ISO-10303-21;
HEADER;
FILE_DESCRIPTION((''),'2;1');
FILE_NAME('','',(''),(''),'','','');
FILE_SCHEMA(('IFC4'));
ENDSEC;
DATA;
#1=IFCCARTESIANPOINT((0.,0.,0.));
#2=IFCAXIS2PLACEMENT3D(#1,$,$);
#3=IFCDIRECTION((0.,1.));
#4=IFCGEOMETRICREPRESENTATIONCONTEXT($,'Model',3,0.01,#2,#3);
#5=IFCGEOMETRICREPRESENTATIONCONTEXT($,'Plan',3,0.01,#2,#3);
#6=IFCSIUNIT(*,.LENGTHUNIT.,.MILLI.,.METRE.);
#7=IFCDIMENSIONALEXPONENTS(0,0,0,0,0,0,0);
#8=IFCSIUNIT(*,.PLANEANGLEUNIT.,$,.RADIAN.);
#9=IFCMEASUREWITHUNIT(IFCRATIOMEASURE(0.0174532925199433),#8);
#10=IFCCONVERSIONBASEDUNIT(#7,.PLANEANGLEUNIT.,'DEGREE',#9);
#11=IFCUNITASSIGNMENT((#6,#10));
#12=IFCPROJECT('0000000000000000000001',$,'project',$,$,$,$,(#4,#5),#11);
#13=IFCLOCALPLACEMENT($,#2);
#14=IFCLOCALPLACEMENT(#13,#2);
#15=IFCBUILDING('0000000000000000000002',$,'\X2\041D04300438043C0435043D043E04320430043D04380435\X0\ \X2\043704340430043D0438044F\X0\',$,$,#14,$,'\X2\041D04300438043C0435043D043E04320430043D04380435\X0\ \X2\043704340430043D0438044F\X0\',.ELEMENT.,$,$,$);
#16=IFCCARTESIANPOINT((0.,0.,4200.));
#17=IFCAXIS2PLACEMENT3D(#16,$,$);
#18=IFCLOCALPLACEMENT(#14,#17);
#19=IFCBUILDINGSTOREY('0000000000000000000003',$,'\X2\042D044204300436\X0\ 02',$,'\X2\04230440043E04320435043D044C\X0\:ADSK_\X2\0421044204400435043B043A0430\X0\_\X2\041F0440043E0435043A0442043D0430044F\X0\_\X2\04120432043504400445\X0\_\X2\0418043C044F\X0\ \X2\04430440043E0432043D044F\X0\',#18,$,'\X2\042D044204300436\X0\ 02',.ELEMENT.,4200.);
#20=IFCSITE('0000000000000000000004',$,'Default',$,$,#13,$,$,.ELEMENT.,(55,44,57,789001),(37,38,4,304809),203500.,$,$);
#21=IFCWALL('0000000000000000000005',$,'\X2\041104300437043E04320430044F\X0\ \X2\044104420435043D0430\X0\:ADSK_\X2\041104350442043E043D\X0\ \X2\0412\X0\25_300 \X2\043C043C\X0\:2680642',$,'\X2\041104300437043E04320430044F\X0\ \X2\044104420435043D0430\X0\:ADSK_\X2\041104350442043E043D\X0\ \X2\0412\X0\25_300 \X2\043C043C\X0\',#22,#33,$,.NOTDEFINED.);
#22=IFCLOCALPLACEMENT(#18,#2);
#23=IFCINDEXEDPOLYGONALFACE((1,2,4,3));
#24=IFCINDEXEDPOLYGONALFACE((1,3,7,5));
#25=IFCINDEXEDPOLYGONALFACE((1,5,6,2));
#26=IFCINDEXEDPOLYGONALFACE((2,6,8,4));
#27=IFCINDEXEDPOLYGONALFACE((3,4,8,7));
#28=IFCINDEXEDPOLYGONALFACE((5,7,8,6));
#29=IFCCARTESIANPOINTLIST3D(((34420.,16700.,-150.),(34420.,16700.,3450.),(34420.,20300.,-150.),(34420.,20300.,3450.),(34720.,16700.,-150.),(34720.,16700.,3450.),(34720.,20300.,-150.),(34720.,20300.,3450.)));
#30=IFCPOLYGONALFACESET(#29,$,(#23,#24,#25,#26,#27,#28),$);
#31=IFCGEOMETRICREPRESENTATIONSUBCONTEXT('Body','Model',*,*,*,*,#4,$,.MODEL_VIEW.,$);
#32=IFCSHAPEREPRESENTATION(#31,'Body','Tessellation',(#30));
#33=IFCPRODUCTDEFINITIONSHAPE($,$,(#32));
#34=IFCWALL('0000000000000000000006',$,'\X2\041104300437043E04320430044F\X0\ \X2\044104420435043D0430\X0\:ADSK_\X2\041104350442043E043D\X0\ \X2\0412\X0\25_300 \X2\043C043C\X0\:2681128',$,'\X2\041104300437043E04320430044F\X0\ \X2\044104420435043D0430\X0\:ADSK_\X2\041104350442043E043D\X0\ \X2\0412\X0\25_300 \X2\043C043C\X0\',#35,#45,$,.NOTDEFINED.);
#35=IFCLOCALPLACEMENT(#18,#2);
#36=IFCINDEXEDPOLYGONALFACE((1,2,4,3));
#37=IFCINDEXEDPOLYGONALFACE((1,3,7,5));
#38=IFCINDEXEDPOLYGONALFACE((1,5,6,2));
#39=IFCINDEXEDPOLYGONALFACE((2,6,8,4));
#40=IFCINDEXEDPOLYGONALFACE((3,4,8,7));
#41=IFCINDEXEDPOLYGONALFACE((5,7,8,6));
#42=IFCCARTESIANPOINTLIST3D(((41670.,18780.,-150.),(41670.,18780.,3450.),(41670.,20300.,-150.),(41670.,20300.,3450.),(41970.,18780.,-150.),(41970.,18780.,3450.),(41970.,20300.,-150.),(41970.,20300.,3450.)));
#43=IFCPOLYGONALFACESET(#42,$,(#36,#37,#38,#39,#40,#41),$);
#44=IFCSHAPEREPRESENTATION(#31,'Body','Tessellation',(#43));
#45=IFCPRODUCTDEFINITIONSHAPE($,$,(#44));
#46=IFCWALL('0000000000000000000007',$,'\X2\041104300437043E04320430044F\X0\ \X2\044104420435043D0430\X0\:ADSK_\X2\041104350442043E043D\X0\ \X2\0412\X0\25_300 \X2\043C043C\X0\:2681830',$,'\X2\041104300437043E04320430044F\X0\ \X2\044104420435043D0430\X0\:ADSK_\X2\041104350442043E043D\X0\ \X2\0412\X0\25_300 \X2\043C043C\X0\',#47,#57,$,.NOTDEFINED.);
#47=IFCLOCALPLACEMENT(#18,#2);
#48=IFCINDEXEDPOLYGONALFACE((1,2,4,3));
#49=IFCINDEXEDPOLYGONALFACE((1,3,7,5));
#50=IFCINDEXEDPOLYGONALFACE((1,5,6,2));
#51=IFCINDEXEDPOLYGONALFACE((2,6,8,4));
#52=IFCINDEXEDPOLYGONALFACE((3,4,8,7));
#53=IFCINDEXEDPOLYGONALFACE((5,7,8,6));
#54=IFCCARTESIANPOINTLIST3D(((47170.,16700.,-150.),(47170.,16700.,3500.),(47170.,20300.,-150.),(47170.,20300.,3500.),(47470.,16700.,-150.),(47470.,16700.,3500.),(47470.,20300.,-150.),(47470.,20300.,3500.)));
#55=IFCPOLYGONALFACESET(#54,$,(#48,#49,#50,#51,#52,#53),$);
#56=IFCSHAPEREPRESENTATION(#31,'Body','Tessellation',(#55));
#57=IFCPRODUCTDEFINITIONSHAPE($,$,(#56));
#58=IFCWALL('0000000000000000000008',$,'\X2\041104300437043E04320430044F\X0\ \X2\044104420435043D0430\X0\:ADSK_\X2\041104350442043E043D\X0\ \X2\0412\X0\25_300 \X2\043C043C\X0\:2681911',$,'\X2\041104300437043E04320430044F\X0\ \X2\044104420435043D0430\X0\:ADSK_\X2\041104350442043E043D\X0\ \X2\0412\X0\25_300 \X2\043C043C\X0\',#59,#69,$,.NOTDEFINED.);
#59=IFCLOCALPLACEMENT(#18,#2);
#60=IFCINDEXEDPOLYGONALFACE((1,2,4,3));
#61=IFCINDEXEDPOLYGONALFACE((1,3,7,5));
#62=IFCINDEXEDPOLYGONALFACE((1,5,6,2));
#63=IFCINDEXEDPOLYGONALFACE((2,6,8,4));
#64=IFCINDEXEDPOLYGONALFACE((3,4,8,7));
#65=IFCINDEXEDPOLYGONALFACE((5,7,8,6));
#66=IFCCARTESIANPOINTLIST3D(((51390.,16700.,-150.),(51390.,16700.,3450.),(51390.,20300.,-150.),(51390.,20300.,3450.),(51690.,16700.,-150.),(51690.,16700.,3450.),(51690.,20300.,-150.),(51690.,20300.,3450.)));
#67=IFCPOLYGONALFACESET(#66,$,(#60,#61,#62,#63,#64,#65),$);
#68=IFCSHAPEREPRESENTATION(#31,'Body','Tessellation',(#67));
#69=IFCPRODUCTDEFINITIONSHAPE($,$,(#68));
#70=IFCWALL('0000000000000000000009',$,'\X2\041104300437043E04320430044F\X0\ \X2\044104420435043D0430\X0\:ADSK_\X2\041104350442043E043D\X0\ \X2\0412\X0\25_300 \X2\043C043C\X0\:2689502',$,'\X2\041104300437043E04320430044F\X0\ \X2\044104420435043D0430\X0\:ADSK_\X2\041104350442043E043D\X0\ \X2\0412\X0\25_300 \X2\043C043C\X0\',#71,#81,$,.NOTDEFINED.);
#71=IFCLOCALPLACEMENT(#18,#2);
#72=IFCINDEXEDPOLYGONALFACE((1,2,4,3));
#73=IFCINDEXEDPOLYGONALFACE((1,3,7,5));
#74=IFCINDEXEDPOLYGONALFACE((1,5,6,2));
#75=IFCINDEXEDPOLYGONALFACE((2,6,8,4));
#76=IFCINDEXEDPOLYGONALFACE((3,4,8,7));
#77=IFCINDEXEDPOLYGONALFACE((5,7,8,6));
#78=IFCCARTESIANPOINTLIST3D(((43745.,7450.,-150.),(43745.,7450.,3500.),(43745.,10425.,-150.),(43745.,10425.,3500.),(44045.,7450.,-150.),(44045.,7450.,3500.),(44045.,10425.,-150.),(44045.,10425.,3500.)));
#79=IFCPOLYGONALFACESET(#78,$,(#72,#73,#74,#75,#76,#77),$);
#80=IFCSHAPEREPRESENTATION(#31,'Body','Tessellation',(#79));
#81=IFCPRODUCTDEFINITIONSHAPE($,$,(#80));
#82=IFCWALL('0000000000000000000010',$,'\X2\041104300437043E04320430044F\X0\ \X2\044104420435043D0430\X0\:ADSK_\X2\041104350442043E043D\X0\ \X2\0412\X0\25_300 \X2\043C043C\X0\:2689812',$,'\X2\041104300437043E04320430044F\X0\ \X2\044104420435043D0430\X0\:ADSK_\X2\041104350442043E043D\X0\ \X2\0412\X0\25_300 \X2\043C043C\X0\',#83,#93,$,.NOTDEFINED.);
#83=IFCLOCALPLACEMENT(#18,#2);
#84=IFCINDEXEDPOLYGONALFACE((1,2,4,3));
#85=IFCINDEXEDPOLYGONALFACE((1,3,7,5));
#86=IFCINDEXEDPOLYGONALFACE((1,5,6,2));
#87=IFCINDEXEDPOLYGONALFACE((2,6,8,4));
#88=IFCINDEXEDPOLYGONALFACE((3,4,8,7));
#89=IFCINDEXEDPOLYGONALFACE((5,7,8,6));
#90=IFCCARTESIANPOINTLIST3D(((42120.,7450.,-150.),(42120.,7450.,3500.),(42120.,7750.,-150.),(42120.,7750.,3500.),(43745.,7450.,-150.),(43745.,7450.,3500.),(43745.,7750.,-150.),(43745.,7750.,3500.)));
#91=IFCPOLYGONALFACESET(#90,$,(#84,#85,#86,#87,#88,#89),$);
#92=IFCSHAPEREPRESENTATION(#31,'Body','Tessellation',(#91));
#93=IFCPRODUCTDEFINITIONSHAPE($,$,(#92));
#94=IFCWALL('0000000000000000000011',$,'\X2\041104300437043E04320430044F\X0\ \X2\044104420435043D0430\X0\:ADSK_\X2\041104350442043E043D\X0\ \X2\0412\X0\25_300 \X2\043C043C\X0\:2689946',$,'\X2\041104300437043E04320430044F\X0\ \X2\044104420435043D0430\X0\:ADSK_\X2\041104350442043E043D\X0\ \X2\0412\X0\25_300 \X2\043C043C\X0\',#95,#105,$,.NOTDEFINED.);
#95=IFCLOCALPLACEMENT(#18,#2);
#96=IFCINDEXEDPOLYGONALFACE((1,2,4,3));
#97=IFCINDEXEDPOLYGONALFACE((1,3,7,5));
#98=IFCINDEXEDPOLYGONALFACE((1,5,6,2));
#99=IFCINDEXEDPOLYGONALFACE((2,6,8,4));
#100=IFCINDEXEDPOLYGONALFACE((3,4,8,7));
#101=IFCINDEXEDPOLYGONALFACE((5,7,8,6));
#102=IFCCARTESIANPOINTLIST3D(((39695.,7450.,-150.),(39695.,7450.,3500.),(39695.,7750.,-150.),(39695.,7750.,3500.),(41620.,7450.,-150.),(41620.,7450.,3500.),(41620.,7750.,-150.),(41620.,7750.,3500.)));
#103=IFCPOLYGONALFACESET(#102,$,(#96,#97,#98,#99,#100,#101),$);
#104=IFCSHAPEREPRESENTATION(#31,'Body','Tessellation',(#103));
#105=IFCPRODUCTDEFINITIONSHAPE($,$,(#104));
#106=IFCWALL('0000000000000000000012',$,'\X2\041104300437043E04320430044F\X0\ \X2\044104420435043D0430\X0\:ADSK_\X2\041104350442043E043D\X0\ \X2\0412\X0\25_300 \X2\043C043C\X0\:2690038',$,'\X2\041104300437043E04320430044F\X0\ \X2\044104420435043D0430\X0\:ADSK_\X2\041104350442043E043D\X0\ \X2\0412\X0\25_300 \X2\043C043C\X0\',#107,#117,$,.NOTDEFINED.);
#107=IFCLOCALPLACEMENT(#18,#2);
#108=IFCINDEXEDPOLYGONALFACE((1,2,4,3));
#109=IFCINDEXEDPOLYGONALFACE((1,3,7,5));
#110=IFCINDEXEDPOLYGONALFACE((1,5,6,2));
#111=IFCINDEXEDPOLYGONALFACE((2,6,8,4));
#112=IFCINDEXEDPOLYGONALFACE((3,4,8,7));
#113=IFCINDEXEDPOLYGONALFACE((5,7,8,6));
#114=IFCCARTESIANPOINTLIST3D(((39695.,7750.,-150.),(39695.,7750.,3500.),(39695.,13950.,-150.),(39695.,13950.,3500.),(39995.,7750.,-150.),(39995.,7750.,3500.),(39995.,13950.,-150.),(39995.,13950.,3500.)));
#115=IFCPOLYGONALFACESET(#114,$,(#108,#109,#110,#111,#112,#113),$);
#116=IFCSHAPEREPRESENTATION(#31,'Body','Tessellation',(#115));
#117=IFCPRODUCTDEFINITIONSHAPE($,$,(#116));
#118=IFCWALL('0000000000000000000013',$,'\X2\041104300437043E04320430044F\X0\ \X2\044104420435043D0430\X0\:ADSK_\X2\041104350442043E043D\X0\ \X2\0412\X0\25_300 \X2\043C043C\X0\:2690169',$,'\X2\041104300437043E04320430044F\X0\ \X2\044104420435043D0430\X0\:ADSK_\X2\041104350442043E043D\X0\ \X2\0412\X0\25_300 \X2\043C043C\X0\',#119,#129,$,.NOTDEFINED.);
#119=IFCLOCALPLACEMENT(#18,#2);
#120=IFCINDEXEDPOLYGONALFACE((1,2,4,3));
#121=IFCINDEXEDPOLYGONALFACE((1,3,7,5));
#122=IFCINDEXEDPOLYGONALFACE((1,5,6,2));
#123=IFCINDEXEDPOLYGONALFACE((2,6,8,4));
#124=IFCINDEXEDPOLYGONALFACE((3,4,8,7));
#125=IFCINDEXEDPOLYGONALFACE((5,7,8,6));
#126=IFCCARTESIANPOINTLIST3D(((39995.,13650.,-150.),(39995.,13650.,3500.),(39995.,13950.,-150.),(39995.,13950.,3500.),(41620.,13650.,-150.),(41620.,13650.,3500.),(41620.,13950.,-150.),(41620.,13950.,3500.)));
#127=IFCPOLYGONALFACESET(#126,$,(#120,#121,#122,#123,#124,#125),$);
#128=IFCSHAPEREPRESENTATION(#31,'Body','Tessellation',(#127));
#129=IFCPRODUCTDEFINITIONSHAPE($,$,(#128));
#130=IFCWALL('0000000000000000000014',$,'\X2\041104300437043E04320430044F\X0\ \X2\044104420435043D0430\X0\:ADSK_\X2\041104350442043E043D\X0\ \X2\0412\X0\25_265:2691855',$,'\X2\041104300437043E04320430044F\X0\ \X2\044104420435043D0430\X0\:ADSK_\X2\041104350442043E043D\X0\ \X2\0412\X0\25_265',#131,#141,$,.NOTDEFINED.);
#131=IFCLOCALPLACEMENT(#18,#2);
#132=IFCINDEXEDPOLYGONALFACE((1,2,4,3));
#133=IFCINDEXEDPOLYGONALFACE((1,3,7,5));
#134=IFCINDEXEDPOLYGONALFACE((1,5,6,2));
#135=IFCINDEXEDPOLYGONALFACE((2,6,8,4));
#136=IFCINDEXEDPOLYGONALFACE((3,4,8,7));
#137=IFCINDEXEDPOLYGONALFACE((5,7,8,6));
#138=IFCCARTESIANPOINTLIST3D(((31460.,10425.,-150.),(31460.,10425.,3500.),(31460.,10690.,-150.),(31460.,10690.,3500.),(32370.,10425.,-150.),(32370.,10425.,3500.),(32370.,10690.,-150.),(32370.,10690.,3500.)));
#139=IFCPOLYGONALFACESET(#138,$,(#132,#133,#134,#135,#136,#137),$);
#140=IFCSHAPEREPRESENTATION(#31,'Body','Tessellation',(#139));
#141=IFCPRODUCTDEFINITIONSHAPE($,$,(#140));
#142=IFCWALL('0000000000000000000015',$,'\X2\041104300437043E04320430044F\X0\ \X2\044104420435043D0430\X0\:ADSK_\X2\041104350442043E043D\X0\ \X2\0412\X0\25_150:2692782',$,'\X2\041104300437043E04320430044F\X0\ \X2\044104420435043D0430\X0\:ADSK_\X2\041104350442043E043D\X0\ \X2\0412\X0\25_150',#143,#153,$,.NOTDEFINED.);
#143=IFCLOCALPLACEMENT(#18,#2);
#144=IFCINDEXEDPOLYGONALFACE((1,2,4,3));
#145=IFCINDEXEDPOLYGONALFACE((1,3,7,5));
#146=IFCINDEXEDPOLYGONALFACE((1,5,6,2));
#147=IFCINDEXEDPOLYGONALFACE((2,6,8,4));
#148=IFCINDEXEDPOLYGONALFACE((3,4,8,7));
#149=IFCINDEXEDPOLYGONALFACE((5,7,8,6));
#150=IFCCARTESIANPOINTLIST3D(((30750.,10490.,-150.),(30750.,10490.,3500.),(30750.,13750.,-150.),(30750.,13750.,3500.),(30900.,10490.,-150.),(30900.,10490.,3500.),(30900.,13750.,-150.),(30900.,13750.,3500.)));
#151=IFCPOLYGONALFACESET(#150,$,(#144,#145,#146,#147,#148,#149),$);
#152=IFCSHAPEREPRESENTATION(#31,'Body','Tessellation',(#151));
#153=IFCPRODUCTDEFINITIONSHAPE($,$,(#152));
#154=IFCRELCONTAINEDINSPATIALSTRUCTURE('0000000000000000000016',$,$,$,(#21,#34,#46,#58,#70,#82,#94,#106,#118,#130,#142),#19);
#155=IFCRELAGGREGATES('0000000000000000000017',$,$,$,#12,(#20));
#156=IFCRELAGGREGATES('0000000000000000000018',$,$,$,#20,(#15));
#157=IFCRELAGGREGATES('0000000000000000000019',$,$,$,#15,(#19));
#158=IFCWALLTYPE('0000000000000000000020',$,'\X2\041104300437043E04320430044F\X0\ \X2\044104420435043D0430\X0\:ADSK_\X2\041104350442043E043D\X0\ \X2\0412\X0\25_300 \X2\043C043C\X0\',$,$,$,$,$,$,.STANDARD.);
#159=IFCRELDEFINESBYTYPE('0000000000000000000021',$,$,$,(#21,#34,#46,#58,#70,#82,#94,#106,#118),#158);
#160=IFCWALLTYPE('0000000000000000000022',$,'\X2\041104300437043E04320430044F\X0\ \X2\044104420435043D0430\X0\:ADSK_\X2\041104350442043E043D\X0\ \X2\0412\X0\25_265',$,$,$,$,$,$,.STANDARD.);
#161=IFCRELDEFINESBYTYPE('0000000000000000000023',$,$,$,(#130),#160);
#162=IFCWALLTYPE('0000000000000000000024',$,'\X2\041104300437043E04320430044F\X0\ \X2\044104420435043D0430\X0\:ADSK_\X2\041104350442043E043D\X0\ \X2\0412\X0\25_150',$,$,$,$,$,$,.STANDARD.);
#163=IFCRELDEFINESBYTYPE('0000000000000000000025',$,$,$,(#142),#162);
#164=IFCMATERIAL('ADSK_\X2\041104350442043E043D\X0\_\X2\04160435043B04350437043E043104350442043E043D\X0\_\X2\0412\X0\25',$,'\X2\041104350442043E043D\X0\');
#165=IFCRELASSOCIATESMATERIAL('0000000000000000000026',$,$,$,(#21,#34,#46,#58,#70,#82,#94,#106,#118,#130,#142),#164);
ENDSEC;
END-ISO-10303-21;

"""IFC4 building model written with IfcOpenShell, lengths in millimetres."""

from ifc_helpers import new_model, entity, si_unit, converted_unit, direction, frame, origin, place, context, subcontext, project, spatial, indexed_curve, outline, extrude, material, type_object, element, save


model = new_model("IFC4")

# Units and contexts
model_context = context("Model", 3, precision=0.01, world=origin(), true_north=direction((0.0, 1.0)))
plan_context = context("Plan", 3, precision=0.01, world=origin(), true_north=direction((0.0, 1.0)))
body_context = subcontext(model_context, "Body", "Model", "MODEL_VIEW")
ifc_project = project(units=[si_unit("LENGTHUNIT", "METRE", prefix="MILLI"), converted_unit("PLANEANGLEUNIT", "DEGREE", entity("IfcRatioMeasure", 0.0174532925199433), si_unit("PLANEANGLEUNIT", "RADIAN"), dimensions=[0, 0, 0, 0, 0, 0, 0])], contexts=[model_context, plan_context])

# Site, building, storey
site_placement = place(None, origin())
site = spatial("IfcSite", under=ifc_project, at=site_placement, Name="Default", CompositionType="ELEMENT", RefLatitude=(55, 44, 57, 789001), RefLongitude=(37, 38, 4, 304809), RefElevation=203500.0)
building_placement = place(site_placement, origin())
building = spatial("IfcBuilding", under=site, at=building_placement, Name="Наименование здания", LongName="Наименование здания", CompositionType="ELEMENT")
storey_placement = place(building_placement, frame((0.0, 0.0, 4200.0)))
storey = spatial("IfcBuildingStorey", under=building, at=storey_placement, Name="Этаж 02", ObjectType="Уровень:ADSK_Стрелка_Проектная_Вверх_Имя уровня", LongName="Этаж 02", CompositionType="ELEMENT", Elevation=4200.0)

# Walls
ifc_material = material(Name="ADSK_Бетон_Железобетон_В25", Category="Бетон")
wall_type_1 = type_object("IfcWallType", Name="Базовая стена:ADSK_Бетон В25_300 мм", PredefinedType="STANDARD")
wall_1_placement = place(storey_placement, frame((34570.0, 20300.0, -150.0), z_axis=(0.0, 0.0, 1.0), x_axis=(0.0, -1.0, 0.0)))
element("IfcWall", 1, at=wall_1_placement, inside=storey, type_object=wall_type_1, material=ifc_material, Name="Базовая стена:ADSK_Бетон В25_300 мм:2680642", ObjectType="Базовая стена:ADSK_Бетон В25_300 мм", PredefinedType="NOTDEFINED", context=body_context, shape_type="SweptSolid", body=[
    extrude(outline(indexed_curve([(3600.0, 150.0), (0.0, 150.0), (0.0, -150.0), (3600.0, -150.0), (3600.0, 150.0)], self_intersect=False)), origin(), (0.0, 0.0, 1.0), 3600.0),
])
wall_2_placement = place(storey_placement, frame((41820.0, 20300.0, -150.0), z_axis=(0.0, 0.0, 1.0), x_axis=(0.0, -1.0, 0.0)))
element("IfcWall", 2, at=wall_2_placement, inside=storey, type_object=wall_type_1, material=ifc_material, Name="Базовая стена:ADSK_Бетон В25_300 мм:2681128", ObjectType="Базовая стена:ADSK_Бетон В25_300 мм", PredefinedType="NOTDEFINED", context=body_context, shape_type="SweptSolid", body=[
    extrude(outline(indexed_curve([(1520.0, 150.0), (0.0, 150.0), (0.0, -150.0), (1520.0, -150.0), (1520.0, 150.0)], self_intersect=False)), origin(), (0.0, 0.0, 1.0), 3600.0),
])
wall_3_placement = place(storey_placement, frame((47320.0, 20300.0, -150.0), z_axis=(0.0, 0.0, 1.0), x_axis=(0.0, -1.0, 0.0)))
element("IfcWall", 3, at=wall_3_placement, inside=storey, type_object=wall_type_1, material=ifc_material, Name="Базовая стена:ADSK_Бетон В25_300 мм:2681830", ObjectType="Базовая стена:ADSK_Бетон В25_300 мм", PredefinedType="NOTDEFINED", context=body_context, shape_type="SweptSolid", body=[
    extrude(outline(indexed_curve([(3600.0, 150.0), (0.0, 150.0), (0.0, -150.0), (3600.0, -150.0), (3600.0, 150.0)], self_intersect=False)), origin(), (0.0, 0.0, 1.0), 3650.0),
])
wall_4_placement = place(storey_placement, frame((51540.0, 20300.0, -150.0), z_axis=(0.0, 0.0, 1.0), x_axis=(0.0, -1.0, 0.0)))
element("IfcWall", 4, at=wall_4_placement, inside=storey, type_object=wall_type_1, material=ifc_material, Name="Базовая стена:ADSK_Бетон В25_300 мм:2681911", ObjectType="Базовая стена:ADSK_Бетон В25_300 мм", PredefinedType="NOTDEFINED", context=body_context, shape_type="SweptSolid", body=[
    extrude(outline(indexed_curve([(3600.0, 150.0), (0.0, 150.0), (0.0, -150.0), (3600.0, -150.0), (3600.0, 150.0)], self_intersect=False)), origin(), (0.0, 0.0, 1.0), 3600.0),
])
wall_5_placement = place(storey_placement, frame((43895.0, 10425.0, -150.0), z_axis=(0.0, 0.0, 1.0), x_axis=(0.0, -1.0, 0.0)))
element("IfcWall", 5, at=wall_5_placement, inside=storey, type_object=wall_type_1, material=ifc_material, Name="Базовая стена:ADSK_Бетон В25_300 мм:2689502", ObjectType="Базовая стена:ADSK_Бетон В25_300 мм", PredefinedType="NOTDEFINED", context=body_context, shape_type="SweptSolid", body=[
    extrude(outline(indexed_curve([(2975.0, 150.0), (0.0, 150.0), (0.0, -150.0), (2975.0, -150.0), (2975.0, 150.0)], self_intersect=False)), origin(), (0.0, 0.0, 1.0), 3650.0),
])
wall_6_placement = place(storey_placement, frame((42120.0, 7600.0, -150.0)))
element("IfcWall", 6, at=wall_6_placement, inside=storey, type_object=wall_type_1, material=ifc_material, Name="Базовая стена:ADSK_Бетон В25_300 мм:2689812", ObjectType="Базовая стена:ADSK_Бетон В25_300 мм", PredefinedType="NOTDEFINED", context=body_context, shape_type="SweptSolid", body=[
    extrude(outline(indexed_curve([(1625.0, 150.0), (0.0, 150.0), (0.0, -150.0), (1625.0, -150.0), (1625.0, 150.0)], self_intersect=False)), origin(), (0.0, 0.0, 1.0), 3650.0),
])
wall_7_placement = place(storey_placement, frame((41620.0, 7600.0, -150.0), z_axis=(0.0, 0.0, 1.0), x_axis=(-1.0, 0.0, 0.0)))
element("IfcWall", 7, at=wall_7_placement, inside=storey, type_object=wall_type_1, material=ifc_material, Name="Базовая стена:ADSK_Бетон В25_300 мм:2689946", ObjectType="Базовая стена:ADSK_Бетон В25_300 мм", PredefinedType="NOTDEFINED", context=body_context, shape_type="SweptSolid", body=[
    extrude(outline(indexed_curve([(1925.0, 150.0), (0.0, 150.0), (0.0, -150.0), (1925.0, -150.0), (1925.0, 150.0)], self_intersect=False)), origin(), (0.0, 0.0, 1.0), 3650.0),
])
wall_8_placement = place(storey_placement, frame((39845.0, 7750.0, -150.0), z_axis=(0.0, 0.0, 1.0), x_axis=(0.0, 1.0, 0.0)))
element("IfcWall", 8, at=wall_8_placement, inside=storey, type_object=wall_type_1, material=ifc_material, Name="Базовая стена:ADSK_Бетон В25_300 мм:2690038", ObjectType="Базовая стена:ADSK_Бетон В25_300 мм", PredefinedType="NOTDEFINED", context=body_context, shape_type="SweptSolid", body=[
    extrude(outline(indexed_curve([(6200.0, 150.0), (0.0, 150.0), (0.0, -150.0), (6200.0, -150.0), (6200.0, 150.0)], self_intersect=False)), origin(), (0.0, 0.0, 1.0), 3650.0),
])
wall_9_placement = place(storey_placement, frame((41620.0, 13800.0, -150.0), z_axis=(0.0, 0.0, 1.0), x_axis=(-1.0, 0.0, 0.0)))
element("IfcWall", 9, at=wall_9_placement, inside=storey, type_object=wall_type_1, material=ifc_material, Name="Базовая стена:ADSK_Бетон В25_300 мм:2690169", ObjectType="Базовая стена:ADSK_Бетон В25_300 мм", PredefinedType="NOTDEFINED", context=body_context, shape_type="SweptSolid", body=[
    extrude(outline(indexed_curve([(1625.0, 150.0), (0.0, 150.0), (0.0, -150.0), (1625.0, -150.0), (1625.0, 150.0)], self_intersect=False)), origin(), (0.0, 0.0, 1.0), 3650.0),
])
wall_type_2 = type_object("IfcWallType", Name="Базовая стена:ADSK_Бетон В25_265", PredefinedType="STANDARD")
wall_10_placement = place(storey_placement, frame((32370.0, 10557.5, -150.0), z_axis=(0.0, 0.0, 1.0), x_axis=(-1.0, 0.0, 0.0)))
element("IfcWall", 10, at=wall_10_placement, inside=storey, type_object=wall_type_2, material=ifc_material, Name="Базовая стена:ADSK_Бетон В25_265:2691855", ObjectType="Базовая стена:ADSK_Бетон В25_265", PredefinedType="NOTDEFINED", context=body_context, shape_type="SweptSolid", body=[
    extrude(outline(indexed_curve([(910.0, 132.5), (0.0, 132.5), (0.0, -132.5), (910.0, -132.5), (910.0, 132.5)], self_intersect=False)), origin(), (0.0, 0.0, 1.0), 3650.0),
])
wall_type_3 = type_object("IfcWallType", Name="Базовая стена:ADSK_Бетон В25_150", PredefinedType="STANDARD")
wall_11_placement = place(storey_placement, frame((30825.0, 13750.0, -150.0), z_axis=(0.0, 0.0, 1.0), x_axis=(0.0, -1.0, 0.0)))
element("IfcWall", 11, at=wall_11_placement, inside=storey, type_object=wall_type_3, material=ifc_material, Name="Базовая стена:ADSK_Бетон В25_150:2692782", ObjectType="Базовая стена:ADSK_Бетон В25_150", PredefinedType="NOTDEFINED", context=body_context, shape_type="SweptSolid", body=[
    extrude(outline(indexed_curve([(3260.0, 75.0), (0.0, 75.0), (0.0, -75.0), (3260.0, -75.0), (3260.0, 75.0)], self_intersect=False)), origin(), (0.0, 0.0, 1.0), 3650.0),
])

save(model, "model.ifc")
